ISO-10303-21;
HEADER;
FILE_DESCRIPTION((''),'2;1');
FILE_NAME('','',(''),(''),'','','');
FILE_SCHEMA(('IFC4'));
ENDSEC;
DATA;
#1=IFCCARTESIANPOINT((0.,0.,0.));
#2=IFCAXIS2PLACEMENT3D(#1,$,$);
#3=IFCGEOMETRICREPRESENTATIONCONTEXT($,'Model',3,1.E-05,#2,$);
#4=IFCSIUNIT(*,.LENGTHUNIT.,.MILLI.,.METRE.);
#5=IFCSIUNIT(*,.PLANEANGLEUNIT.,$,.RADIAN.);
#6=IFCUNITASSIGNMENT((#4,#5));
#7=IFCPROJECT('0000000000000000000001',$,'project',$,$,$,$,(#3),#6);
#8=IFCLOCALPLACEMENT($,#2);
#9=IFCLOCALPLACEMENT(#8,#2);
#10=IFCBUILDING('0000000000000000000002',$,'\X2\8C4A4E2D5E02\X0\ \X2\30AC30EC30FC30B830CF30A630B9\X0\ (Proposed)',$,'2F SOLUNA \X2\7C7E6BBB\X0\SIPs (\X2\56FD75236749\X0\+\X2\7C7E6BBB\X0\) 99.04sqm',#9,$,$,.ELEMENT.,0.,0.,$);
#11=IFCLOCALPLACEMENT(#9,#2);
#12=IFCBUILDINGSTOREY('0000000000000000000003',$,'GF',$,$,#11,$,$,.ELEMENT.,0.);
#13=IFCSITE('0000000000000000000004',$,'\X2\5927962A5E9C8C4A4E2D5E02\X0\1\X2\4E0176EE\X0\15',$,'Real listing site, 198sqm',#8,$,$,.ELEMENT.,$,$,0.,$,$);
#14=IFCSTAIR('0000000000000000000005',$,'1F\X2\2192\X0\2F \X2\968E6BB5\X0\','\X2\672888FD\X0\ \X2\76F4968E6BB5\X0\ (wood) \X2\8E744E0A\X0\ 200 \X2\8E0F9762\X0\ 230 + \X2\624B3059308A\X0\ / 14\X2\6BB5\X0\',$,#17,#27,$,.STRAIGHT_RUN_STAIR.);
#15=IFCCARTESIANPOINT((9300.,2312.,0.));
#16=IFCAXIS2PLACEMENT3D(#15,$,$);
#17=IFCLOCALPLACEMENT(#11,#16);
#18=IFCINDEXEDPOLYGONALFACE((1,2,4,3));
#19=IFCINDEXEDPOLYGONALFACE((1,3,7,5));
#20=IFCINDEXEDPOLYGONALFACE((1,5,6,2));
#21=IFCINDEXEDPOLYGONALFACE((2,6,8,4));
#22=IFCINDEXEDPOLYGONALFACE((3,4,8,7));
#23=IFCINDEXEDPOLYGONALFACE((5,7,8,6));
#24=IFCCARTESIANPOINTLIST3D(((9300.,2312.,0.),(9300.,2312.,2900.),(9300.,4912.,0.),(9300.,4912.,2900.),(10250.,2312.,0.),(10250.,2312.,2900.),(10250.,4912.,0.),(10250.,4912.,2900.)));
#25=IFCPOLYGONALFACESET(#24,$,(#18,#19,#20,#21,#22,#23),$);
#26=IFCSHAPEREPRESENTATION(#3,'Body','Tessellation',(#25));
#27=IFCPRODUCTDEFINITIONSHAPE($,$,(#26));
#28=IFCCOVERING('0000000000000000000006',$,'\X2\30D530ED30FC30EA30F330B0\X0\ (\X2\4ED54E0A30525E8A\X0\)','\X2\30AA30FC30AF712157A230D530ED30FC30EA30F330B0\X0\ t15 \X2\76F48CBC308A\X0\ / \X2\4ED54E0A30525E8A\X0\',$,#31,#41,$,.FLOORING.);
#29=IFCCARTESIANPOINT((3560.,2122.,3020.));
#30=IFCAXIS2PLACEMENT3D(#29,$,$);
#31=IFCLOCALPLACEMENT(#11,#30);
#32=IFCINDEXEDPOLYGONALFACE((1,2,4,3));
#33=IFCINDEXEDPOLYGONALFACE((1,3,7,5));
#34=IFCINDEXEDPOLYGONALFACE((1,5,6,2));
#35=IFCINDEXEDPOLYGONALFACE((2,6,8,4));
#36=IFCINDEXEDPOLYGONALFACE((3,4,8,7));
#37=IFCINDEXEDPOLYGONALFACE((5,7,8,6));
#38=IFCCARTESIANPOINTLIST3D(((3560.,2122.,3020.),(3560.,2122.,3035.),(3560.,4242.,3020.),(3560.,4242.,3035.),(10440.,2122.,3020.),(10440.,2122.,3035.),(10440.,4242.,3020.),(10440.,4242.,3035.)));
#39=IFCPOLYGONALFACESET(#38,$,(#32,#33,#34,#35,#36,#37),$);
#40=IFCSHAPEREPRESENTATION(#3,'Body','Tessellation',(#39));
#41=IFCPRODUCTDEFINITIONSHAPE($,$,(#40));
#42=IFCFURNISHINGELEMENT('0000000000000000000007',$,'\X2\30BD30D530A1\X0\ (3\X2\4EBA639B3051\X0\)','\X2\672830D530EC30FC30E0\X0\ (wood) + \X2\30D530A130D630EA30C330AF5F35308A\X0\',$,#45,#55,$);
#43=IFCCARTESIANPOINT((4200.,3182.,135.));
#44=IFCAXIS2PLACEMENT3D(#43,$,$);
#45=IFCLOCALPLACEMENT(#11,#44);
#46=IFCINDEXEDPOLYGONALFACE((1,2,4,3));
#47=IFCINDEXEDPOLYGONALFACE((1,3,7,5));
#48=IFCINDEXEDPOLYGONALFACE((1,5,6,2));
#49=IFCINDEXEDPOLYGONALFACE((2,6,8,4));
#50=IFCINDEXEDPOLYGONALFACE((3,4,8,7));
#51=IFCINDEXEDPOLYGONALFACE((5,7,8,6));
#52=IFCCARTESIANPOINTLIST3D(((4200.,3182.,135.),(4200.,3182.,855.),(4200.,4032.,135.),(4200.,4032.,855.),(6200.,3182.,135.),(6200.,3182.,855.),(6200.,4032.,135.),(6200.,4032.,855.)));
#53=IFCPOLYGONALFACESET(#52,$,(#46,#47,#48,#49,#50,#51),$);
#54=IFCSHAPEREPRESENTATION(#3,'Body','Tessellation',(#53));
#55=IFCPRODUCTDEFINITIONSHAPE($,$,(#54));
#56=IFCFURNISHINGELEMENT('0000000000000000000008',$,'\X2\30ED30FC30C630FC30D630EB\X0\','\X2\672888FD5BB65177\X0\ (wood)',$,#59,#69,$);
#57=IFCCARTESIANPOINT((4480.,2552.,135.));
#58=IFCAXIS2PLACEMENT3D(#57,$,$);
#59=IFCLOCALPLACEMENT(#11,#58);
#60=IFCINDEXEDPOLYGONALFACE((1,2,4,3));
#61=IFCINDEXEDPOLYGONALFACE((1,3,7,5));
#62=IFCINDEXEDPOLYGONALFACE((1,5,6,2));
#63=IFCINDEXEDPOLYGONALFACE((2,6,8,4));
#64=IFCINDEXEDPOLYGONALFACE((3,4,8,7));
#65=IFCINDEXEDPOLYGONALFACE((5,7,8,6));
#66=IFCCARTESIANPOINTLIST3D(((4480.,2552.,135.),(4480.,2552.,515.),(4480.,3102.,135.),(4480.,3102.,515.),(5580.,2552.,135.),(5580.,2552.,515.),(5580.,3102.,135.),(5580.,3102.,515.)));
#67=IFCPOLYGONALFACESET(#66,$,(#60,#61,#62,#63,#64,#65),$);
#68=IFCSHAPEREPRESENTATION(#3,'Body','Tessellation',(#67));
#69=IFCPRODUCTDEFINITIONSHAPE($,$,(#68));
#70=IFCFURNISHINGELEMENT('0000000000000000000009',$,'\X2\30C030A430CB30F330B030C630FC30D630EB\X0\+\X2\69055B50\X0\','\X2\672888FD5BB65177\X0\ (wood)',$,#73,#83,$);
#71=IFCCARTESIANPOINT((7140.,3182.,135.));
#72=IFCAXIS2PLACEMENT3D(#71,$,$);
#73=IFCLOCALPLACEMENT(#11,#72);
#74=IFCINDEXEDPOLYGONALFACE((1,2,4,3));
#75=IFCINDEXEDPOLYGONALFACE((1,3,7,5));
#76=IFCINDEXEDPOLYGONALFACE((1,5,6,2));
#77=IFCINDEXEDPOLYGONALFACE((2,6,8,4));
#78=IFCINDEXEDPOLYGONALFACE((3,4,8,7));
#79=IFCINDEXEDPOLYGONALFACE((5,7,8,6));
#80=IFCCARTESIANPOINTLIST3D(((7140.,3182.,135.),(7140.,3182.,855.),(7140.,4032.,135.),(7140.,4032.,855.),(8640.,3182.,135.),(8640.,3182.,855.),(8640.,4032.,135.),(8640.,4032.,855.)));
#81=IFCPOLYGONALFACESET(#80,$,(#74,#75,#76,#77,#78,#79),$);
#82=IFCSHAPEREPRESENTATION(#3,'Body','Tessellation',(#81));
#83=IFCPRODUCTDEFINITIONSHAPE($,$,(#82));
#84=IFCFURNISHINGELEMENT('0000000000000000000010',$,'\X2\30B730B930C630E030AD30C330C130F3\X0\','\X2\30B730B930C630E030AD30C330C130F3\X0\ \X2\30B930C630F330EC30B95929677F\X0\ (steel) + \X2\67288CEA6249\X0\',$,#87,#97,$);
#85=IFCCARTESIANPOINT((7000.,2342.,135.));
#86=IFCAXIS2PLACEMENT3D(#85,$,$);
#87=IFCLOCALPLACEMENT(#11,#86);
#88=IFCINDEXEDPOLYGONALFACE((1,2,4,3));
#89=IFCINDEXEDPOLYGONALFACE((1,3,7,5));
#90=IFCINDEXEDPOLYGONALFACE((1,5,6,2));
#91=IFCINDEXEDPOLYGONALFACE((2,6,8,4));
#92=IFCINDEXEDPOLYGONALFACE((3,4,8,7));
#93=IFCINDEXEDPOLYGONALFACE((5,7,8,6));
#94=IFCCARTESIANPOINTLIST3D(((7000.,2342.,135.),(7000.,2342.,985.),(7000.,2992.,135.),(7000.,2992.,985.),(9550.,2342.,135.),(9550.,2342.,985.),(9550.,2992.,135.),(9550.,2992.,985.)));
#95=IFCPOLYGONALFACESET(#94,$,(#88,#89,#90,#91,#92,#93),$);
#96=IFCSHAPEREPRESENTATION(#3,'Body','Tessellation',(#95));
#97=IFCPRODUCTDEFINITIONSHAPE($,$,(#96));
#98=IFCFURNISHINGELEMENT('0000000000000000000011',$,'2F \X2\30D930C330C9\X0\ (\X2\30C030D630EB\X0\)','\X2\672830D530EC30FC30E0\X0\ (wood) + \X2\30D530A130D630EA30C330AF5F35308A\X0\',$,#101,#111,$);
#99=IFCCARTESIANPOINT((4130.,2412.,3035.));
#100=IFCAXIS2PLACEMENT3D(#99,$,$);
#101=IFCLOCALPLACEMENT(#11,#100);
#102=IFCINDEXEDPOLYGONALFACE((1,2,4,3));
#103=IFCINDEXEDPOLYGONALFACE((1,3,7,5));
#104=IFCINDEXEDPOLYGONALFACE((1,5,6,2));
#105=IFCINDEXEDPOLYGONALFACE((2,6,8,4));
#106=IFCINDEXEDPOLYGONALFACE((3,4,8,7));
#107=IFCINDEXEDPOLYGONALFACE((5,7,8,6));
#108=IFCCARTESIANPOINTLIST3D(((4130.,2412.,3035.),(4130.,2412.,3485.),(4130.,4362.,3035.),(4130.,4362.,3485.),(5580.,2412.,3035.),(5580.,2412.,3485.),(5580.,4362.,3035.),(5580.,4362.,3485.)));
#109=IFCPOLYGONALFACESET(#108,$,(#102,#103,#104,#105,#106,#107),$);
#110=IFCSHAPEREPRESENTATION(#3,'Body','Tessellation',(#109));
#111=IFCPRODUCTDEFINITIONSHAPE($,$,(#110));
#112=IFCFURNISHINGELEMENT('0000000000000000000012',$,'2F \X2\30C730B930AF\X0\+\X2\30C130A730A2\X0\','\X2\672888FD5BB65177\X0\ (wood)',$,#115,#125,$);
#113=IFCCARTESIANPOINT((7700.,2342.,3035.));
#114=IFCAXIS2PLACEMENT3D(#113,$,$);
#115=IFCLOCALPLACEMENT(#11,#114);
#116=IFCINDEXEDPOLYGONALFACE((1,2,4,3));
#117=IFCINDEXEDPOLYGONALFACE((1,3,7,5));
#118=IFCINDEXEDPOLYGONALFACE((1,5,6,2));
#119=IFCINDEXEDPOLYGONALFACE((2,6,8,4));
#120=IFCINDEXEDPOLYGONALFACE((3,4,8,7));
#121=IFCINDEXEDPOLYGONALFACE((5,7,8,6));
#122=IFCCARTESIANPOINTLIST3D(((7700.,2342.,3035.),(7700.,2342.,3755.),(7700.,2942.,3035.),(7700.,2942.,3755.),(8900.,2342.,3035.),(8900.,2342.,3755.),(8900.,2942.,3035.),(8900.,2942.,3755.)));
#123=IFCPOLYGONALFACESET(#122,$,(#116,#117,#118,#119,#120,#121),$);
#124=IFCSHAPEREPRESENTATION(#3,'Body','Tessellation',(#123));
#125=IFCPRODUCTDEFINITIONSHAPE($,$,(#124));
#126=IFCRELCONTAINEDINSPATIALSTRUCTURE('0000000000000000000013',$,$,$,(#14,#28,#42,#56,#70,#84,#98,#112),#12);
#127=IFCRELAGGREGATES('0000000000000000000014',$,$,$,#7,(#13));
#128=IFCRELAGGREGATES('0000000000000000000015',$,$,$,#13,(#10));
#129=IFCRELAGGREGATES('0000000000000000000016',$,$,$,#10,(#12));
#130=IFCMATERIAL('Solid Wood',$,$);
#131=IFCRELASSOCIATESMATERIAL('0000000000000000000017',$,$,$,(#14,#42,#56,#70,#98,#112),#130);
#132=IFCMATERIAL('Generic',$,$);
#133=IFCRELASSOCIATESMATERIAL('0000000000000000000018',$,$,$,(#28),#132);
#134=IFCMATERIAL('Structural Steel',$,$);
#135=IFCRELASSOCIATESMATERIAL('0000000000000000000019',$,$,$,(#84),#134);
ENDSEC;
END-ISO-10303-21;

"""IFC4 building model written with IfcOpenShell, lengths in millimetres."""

from ifc_helpers import new_model, si_unit, frame, frame_2d, origin, place, context, project, spatial, rectangle, extrude, material, element, save


model = new_model("IFC4")

# Units and contexts
model_context = context("Model", 3, precision=1e-05, world=origin())
ifc_project = project(units=[si_unit("LENGTHUNIT", "METRE", prefix="MILLI"), si_unit("PLANEANGLEUNIT", "RADIAN")], contexts=[model_context])

# Site, building, storey
site_placement = place(None, origin())
site = spatial("IfcSite", under=ifc_project, at=site_placement, Name="大阪府豊中市1丁目15", ObjectType="Real listing site, 198sqm", CompositionType="ELEMENT", RefElevation=0.0)
building_placement = place(site_placement, origin())
building = spatial("IfcBuilding", under=site, at=building_placement, Name="豊中市 ガレージハウス (Proposed)", ObjectType="2F SOLUNA 籾殻SIPs (国産杉+籾殻) 99.04sqm", CompositionType="ELEMENT", ElevationOfRefHeight=0.0, ElevationOfTerrain=0.0)
storey_placement = place(building_placement, origin())
storey = spatial("IfcBuildingStorey", under=building, at=storey_placement, Name="GF", CompositionType="ELEMENT", Elevation=0.0)

# Shared definitions
ifc_material_1 = material(Name="Solid Wood")

# Shared definitions
ifc_material_2 = material(Name="Generic")

# Stair
stair_placement = place(storey_placement, frame((9300.0, 2312.0, 0.0)))
element("IfcStair", 1, at=stair_placement, inside=storey, material=ifc_material_1, Name="1F→2F 階段", Description="木製 直階段 (wood) 蹴上 200 踏面 230 + 手すり / 14段", PredefinedType="STRAIGHT_RUN_STAIR", context=model_context, shape_type="SweptSolid", body=[
    extrude(rectangle(XDim=950.0, YDim=2600.0, at=frame_2d((475.0, 1300.0))), frame((9300.0, 2312.0, 0.0)), (0.0, 0.0, 1.0), 2900.0),
])

# Covering
covering_placement = place(storey_placement, frame((3560.0, 2122.0, 3020.0)))
element("IfcCovering", 2, at=covering_placement, inside=storey, material=ifc_material_2, Name="フローリング (仕上げ床)", Description="オーク無垢フローリング t15 直貼り / 仕上げ床", PredefinedType="FLOORING", context=model_context, shape_type="SweptSolid", body=[
    extrude(rectangle(XDim=6880.0, YDim=2120.0, at=frame_2d((3440.0, 1060.0))), frame((3560.0, 2122.0, 3020.0)), (0.0, 0.0, 1.0), 15.0),
])

# Furnishing elements
furnishing_1_placement = place(storey_placement, frame((4200.0, 3182.0, 135.0)))
element("IfcFurnishingElement", 3, at=furnishing_1_placement, inside=storey, material=ifc_material_1, Name="ソファ (3人掛け)", Description="木フレーム (wood) + ファブリック張り", context=model_context, shape_type="SweptSolid", body=[
    extrude(rectangle(XDim=2000.0, YDim=850.0, at=frame_2d((1000.0, 425.0))), frame((4200.0, 3182.0, 135.0)), (0.0, 0.0, 1.0), 720.0),
])
furnishing_2_placement = place(storey_placement, frame((4480.0, 2552.0, 135.0)))
element("IfcFurnishingElement", 4, at=furnishing_2_placement, inside=storey, material=ifc_material_1, Name="ローテーブル", Description="木製家具 (wood)", context=model_context, shape_type="SweptSolid", body=[
    extrude(rectangle(XDim=1100.0, YDim=550.0, at=frame_2d((550.0, 275.0))), frame((4480.0, 2552.0, 135.0)), (0.0, 0.0, 1.0), 380.0),
])
furnishing_3_placement = place(storey_placement, frame((7140.0, 3182.0, 135.0)))
element("IfcFurnishingElement", 5, at=furnishing_3_placement, inside=storey, material=ifc_material_1, Name="ダイニングテーブル+椅子", Description="木製家具 (wood)", context=model_context, shape_type="SweptSolid", body=[
    extrude(rectangle(XDim=1500.0, YDim=850.0, at=frame_2d((750.0, 425.0))), frame((7140.0, 3182.0, 135.0)), (0.0, 0.0, 1.0), 720.0),
])
ifc_material_3 = material(Name="Structural Steel")
furnishing_4_placement = place(storey_placement, frame((7000.0, 2342.0, 135.0)))
element("IfcFurnishingElement", 6, at=furnishing_4_placement, inside=storey, material=ifc_material_3, Name="システムキッチン", Description="システムキッチン ステンレス天板 (steel) + 木質扉", context=model_context, shape_type="SweptSolid", body=[
    extrude(rectangle(XDim=2550.0, YDim=650.0, at=frame_2d((1275.0, 325.0))), frame((7000.0, 2342.0, 135.0)), (0.0, 0.0, 1.0), 850.0),
])
furnishing_5_placement = place(storey_placement, frame((4130.0, 2412.0, 3035.0)))
element("IfcFurnishingElement", 7, at=furnishing_5_placement, inside=storey, material=ifc_material_1, Name="2F ベッド (ダブル)", Description="木フレーム (wood) + ファブリック張り", context=model_context, shape_type="SweptSolid", body=[
    extrude(rectangle(XDim=1450.0, YDim=1950.0, at=frame_2d((725.0, 975.0))), frame((4130.0, 2412.0, 3035.0)), (0.0, 0.0, 1.0), 450.0),
])
furnishing_6_placement = place(storey_placement, frame((7700.0, 2342.0, 3035.0)))
element("IfcFurnishingElement", 8, at=furnishing_6_placement, inside=storey, material=ifc_material_1, Name="2F デスク+チェア", Description="木製家具 (wood)", context=model_context, shape_type="SweptSolid", body=[
    extrude(rectangle(XDim=1200.0, YDim=600.0, at=frame_2d((600.0, 300.0))), frame((7700.0, 2342.0, 3035.0)), (0.0, 0.0, 1.0), 720.0),
])

save(model, "model.ifc")
